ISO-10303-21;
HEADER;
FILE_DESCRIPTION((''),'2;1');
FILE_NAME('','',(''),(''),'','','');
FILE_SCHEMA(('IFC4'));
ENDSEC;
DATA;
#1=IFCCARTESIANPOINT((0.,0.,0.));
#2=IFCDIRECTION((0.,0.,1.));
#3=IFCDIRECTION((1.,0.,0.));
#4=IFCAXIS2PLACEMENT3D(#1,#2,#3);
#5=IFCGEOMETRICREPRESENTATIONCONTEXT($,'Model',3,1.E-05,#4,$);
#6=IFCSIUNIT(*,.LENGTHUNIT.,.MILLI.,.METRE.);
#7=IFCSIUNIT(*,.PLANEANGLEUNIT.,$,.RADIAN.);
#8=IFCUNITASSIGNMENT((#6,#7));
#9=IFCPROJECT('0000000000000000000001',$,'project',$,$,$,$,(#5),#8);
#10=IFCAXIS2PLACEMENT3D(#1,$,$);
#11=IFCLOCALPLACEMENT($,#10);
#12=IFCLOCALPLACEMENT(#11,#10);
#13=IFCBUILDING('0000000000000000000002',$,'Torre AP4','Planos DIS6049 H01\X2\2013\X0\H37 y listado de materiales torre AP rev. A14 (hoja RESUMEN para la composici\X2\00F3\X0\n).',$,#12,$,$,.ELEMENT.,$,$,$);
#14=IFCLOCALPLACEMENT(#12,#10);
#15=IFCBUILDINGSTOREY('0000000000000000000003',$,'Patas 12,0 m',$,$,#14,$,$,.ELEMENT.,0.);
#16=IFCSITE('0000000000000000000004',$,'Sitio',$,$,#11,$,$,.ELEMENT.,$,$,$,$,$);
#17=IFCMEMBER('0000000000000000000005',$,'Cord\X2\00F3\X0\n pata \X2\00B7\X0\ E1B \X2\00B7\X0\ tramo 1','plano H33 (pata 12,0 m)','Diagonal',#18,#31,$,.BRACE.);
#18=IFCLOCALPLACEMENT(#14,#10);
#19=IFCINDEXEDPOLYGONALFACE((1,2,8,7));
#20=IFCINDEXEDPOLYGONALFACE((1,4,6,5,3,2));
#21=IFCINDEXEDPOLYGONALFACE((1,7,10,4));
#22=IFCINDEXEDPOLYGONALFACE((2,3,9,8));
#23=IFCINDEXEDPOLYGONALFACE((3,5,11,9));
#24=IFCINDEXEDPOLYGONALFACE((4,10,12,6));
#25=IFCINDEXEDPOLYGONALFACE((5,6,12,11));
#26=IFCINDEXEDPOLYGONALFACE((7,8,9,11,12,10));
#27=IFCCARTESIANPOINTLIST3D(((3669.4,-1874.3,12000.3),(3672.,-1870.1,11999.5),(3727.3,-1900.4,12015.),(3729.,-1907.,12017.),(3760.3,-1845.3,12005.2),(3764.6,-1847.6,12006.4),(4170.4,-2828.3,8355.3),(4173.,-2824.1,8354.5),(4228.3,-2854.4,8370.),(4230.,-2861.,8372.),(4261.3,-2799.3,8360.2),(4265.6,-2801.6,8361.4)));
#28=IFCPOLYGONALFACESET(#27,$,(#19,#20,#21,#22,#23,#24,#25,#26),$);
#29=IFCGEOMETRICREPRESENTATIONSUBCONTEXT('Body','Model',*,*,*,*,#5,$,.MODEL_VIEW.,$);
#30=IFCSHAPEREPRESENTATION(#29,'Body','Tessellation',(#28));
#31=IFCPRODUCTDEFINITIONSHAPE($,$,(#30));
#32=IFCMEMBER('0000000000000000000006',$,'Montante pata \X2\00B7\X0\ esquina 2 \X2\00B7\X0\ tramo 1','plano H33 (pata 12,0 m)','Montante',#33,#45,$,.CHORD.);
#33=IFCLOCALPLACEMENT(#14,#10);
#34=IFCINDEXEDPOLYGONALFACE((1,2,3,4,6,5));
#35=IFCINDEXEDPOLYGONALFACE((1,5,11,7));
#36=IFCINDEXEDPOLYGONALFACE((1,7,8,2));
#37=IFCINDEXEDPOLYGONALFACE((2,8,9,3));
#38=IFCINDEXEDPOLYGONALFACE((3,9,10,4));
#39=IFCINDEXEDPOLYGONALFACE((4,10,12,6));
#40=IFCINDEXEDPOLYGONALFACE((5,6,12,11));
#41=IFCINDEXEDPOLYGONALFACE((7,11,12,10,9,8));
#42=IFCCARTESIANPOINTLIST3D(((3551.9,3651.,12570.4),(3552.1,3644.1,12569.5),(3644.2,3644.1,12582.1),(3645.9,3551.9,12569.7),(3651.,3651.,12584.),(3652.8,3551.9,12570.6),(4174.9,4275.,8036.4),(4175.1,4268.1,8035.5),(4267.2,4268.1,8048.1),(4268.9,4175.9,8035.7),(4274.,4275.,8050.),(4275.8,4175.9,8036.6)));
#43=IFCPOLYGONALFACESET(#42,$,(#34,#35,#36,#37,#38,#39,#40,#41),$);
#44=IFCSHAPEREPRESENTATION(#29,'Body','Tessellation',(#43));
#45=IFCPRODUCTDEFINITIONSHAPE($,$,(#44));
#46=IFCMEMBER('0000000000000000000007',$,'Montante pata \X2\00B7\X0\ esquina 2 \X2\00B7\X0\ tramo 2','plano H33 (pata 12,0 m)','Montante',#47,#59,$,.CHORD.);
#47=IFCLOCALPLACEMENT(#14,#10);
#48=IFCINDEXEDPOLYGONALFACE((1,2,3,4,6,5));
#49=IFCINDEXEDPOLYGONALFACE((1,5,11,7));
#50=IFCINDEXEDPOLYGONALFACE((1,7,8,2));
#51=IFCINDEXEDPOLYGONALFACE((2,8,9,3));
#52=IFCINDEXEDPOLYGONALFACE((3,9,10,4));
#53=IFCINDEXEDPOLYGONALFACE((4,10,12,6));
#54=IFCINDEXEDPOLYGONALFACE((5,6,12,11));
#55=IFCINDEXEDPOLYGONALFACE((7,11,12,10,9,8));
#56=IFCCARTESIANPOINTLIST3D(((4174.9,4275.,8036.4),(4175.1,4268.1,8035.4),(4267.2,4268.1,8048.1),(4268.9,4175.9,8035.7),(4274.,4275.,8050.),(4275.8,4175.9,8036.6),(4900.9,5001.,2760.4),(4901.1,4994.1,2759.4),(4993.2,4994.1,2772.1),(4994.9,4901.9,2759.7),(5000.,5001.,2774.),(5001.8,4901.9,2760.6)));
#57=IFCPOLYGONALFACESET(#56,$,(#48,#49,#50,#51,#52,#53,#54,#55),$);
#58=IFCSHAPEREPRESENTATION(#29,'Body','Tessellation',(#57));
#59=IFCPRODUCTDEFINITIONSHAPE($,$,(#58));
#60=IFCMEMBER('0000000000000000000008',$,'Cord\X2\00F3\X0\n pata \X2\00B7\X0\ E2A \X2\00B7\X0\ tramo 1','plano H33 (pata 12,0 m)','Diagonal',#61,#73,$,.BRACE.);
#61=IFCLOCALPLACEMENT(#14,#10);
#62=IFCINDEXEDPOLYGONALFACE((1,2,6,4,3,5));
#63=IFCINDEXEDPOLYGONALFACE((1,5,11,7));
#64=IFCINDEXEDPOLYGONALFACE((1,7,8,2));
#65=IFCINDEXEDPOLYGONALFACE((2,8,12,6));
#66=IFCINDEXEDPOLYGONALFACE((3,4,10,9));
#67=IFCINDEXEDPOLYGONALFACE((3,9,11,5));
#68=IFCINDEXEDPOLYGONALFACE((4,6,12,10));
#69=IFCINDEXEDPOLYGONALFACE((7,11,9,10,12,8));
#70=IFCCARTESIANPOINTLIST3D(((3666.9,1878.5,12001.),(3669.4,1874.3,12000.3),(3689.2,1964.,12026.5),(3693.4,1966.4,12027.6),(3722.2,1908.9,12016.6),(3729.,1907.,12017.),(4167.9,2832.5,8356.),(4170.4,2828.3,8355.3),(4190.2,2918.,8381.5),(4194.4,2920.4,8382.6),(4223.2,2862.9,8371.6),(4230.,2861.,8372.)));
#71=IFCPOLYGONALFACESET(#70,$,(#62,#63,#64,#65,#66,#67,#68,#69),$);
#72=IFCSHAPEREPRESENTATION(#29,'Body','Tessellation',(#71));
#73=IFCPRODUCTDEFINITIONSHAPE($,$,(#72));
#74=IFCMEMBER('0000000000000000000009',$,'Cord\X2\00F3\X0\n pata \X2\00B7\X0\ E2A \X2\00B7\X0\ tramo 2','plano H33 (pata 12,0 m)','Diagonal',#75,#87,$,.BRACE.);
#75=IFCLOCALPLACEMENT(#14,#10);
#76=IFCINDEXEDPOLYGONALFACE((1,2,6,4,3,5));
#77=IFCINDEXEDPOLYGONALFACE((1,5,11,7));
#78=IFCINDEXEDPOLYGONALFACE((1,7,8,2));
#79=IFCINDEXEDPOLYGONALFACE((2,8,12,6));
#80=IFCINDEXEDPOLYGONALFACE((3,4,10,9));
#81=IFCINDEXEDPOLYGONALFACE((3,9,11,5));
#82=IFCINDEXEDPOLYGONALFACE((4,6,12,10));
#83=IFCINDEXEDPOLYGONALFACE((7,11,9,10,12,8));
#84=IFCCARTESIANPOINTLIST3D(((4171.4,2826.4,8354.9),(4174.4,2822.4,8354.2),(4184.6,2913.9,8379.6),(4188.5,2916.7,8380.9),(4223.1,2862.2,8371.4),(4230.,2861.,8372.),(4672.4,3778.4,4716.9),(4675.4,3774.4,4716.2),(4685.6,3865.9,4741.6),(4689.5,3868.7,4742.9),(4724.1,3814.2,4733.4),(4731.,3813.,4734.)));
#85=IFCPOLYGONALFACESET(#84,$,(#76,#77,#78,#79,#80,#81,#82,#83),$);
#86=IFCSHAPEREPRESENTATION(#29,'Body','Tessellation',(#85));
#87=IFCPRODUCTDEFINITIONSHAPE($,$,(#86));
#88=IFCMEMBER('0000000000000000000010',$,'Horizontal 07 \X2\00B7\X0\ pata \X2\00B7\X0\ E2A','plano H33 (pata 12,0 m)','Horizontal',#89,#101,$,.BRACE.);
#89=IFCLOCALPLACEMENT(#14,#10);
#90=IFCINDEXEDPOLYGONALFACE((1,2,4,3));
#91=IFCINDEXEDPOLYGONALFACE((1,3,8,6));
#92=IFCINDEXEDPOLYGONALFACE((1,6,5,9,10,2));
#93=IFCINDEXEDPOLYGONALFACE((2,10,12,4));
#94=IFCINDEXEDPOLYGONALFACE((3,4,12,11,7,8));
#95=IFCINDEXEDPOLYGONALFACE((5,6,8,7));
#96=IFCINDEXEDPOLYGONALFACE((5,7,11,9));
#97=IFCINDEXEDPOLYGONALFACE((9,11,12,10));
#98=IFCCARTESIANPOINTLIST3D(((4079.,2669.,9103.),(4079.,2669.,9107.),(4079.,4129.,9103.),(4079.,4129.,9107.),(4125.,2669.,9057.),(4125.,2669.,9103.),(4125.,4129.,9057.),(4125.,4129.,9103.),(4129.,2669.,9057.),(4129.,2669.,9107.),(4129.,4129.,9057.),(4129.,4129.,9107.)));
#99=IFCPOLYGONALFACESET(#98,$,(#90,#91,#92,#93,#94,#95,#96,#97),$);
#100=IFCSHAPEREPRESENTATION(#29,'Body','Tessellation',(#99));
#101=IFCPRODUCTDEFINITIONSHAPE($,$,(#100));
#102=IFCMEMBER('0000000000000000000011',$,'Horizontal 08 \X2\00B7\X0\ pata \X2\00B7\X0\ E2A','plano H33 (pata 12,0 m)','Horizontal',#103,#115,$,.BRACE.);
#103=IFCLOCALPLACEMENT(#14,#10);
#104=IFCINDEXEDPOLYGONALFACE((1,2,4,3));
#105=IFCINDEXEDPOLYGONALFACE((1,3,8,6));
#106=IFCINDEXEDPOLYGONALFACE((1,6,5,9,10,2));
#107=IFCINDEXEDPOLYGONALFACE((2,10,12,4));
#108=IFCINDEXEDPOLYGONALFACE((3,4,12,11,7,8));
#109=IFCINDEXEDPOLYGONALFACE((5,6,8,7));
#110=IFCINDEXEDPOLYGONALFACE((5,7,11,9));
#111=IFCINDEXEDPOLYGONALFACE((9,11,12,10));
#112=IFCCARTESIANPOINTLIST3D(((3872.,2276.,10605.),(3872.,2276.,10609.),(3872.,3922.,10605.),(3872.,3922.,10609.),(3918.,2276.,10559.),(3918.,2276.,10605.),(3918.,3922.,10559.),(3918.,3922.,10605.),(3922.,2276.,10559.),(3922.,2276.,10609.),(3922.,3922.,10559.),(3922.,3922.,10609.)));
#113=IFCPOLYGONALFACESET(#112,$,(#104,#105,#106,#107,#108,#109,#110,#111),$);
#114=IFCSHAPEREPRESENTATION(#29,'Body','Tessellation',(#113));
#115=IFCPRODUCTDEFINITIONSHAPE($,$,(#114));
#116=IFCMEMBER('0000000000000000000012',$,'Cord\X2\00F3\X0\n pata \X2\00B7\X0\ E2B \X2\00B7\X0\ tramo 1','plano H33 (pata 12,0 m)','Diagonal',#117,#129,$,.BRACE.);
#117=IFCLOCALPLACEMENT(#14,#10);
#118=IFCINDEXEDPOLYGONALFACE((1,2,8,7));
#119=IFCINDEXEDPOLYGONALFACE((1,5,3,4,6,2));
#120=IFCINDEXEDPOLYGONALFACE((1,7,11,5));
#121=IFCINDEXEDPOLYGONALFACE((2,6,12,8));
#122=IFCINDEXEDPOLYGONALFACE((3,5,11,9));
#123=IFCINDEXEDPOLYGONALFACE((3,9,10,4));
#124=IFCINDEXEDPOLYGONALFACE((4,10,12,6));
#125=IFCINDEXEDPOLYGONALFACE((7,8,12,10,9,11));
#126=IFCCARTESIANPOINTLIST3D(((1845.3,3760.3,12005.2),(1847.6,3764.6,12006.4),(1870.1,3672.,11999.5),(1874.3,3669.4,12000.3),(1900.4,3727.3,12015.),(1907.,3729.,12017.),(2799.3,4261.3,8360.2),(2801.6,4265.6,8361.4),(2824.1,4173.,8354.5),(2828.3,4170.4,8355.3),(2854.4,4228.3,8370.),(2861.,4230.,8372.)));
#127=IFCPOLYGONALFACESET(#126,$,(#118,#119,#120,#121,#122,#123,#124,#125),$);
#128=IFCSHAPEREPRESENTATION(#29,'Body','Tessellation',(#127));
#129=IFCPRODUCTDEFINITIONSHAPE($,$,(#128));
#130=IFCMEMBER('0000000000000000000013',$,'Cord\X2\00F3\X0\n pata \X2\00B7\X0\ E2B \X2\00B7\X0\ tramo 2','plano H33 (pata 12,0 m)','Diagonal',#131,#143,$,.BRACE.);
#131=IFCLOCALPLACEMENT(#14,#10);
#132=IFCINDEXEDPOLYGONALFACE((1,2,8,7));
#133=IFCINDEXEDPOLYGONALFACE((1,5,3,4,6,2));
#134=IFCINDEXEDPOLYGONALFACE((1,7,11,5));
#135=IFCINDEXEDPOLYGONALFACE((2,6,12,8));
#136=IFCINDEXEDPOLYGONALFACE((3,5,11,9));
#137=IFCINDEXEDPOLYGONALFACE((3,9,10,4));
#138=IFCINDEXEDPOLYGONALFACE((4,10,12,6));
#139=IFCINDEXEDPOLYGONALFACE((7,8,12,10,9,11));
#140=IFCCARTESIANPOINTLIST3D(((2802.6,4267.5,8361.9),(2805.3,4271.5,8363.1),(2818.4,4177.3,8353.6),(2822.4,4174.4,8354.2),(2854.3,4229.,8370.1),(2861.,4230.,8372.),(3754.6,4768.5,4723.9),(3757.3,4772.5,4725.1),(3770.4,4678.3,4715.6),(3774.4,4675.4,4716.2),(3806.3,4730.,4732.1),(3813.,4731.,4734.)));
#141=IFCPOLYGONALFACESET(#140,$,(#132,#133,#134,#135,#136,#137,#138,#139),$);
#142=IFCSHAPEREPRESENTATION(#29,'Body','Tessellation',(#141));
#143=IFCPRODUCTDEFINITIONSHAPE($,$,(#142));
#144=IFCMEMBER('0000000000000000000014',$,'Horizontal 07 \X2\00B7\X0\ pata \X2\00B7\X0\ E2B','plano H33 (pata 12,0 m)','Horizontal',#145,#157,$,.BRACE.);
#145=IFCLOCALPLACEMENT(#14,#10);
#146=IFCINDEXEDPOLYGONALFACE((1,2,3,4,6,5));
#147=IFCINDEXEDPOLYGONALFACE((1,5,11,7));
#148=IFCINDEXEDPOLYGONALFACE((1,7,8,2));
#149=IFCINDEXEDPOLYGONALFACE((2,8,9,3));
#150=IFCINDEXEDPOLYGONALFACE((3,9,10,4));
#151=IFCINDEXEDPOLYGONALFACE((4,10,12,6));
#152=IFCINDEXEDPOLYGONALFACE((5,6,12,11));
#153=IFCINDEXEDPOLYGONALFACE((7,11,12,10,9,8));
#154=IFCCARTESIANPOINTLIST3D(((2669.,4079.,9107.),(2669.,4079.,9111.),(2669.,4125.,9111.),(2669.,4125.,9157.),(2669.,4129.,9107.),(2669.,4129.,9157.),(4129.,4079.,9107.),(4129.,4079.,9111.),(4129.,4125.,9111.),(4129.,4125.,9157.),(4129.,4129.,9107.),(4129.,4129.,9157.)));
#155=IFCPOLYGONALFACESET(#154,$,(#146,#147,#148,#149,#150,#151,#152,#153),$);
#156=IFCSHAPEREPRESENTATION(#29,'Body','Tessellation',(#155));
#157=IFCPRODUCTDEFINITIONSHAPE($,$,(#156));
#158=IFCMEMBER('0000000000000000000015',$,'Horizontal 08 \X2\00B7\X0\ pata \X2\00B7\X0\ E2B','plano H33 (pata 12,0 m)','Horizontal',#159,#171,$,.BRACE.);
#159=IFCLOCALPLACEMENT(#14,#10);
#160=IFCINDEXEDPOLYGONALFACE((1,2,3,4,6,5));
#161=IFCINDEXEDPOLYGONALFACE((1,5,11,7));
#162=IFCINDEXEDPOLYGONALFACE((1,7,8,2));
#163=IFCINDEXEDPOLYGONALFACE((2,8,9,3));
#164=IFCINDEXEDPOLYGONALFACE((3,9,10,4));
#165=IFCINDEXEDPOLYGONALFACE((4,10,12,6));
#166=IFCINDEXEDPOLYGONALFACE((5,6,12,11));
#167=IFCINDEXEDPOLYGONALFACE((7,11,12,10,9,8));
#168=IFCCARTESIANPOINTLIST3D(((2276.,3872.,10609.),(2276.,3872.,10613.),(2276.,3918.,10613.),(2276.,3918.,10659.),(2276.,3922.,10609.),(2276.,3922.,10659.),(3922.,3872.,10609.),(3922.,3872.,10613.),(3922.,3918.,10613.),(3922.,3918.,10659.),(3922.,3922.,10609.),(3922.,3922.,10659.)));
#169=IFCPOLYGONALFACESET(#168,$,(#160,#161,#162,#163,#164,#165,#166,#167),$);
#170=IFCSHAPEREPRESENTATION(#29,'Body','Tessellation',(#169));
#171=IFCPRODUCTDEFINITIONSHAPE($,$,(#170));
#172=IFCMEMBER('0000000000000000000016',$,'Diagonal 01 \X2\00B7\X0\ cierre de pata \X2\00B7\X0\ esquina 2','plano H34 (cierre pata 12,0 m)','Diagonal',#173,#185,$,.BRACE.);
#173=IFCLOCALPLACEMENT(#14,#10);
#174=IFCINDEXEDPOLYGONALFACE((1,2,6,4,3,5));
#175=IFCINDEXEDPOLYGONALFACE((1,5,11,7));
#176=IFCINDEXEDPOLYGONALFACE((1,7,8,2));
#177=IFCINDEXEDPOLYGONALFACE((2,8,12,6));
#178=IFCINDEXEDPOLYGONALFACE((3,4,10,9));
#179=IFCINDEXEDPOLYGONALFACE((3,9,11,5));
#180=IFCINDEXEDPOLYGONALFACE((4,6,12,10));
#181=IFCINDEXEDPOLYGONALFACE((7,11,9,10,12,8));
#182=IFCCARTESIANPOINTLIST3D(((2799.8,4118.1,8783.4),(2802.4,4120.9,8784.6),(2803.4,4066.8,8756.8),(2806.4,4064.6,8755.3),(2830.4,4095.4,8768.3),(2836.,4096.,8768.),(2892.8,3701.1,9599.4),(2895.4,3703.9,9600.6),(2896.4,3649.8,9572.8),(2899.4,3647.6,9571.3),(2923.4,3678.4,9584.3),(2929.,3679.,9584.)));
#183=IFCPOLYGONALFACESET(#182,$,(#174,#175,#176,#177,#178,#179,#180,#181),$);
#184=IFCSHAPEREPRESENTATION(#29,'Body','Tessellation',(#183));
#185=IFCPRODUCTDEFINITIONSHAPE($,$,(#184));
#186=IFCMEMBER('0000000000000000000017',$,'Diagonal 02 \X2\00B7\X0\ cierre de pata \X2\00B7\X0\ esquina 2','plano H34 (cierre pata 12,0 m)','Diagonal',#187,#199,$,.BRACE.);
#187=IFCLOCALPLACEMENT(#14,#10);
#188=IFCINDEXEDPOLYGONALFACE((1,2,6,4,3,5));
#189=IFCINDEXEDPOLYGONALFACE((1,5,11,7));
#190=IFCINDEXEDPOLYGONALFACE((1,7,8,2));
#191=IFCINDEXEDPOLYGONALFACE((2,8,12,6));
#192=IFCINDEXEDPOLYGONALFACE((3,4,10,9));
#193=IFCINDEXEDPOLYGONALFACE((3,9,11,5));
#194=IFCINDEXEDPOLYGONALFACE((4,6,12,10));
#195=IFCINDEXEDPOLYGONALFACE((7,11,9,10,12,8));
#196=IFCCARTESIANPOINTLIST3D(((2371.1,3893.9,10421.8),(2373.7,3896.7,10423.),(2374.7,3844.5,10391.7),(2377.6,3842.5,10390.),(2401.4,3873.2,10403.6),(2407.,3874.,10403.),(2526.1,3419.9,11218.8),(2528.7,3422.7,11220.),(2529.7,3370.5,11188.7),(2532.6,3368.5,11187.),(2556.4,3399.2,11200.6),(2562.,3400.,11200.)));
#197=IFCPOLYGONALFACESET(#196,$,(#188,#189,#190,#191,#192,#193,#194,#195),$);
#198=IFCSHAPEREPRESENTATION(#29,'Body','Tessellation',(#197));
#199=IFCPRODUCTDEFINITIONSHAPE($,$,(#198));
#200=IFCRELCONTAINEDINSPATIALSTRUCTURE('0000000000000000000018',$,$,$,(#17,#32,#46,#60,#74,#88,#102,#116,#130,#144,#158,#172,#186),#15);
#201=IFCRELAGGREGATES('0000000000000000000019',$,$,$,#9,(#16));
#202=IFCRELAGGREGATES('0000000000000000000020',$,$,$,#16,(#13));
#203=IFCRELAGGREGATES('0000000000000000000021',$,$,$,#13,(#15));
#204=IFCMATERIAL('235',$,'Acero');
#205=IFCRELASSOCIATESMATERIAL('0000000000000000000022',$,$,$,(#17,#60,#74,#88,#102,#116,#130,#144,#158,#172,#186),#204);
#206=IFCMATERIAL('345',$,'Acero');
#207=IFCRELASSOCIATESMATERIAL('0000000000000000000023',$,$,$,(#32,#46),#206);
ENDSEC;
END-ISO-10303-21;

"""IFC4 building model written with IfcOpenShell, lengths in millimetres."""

from ifc_helpers import new_model, si_unit, frame, frame_2d, origin, origin_with_axes, place, context, subcontext, project, spatial, l_section, extrude, material, element, save


model = new_model("IFC4")

# Units and contexts
model_context = context("Model", 3, precision=1e-05, world=origin_with_axes())
body_context = subcontext(model_context, "Body", "Model", "MODEL_VIEW")
ifc_project = project(units=[si_unit("LENGTHUNIT", "METRE", prefix="MILLI"), si_unit("PLANEANGLEUNIT", "RADIAN")], contexts=[model_context])

# Site, building, storey
site_placement = place(None, origin())
site = spatial("IfcSite", under=ifc_project, at=site_placement, Name="Sitio", CompositionType="ELEMENT")
building_placement = place(site_placement, origin())
building = spatial("IfcBuilding", under=site, at=building_placement, Name="Torre AP4", Description="Planos DIS6049 H01–H37 y listado de materiales torre AP rev. A14 (hoja RESUMEN para la composición).", CompositionType="ELEMENT")
storey_placement = place(building_placement, origin())
storey = spatial("IfcBuildingStorey", under=building, at=storey_placement, Name="Patas 12,0 m", CompositionType="ELEMENT", Elevation=0.0)

# Members
ifc_material_1 = material(Name="235", Category="Acero")
member_1_placement = place(storey_placement, frame((3729.0, -1907.0, 12017.0), z_axis=(0.13181, -0.250991, -0.958973), x_axis=(-0.851254, 0.467044, -0.239242)))
element("IfcMember", 1, at=member_1_placement, inside=storey, material=ifc_material_1, Name="Cordón pata · E1B · tramo 1", Description="plano H33 (pata 12,0 m)", ObjectType="Diagonal", PredefinedType="BRACE", context=body_context, shape_type="SweptSolid", body=[
    extrude(l_section(Depth=70.0, Width=70.0, Thickness=5.0, at=frame_2d((35.0, 35.0))), None, (0.0, 0.0, 1.0), 3800.9),
])
ifc_material_2 = material(Name="345", Category="Acero")
member_2_placement = place(storey_placement, frame((3651.0, 3651.0, 12584.0), z_axis=(0.134879, 0.135096, -0.981609), x_axis=(0.01839, -0.990833, -0.133838)))
element("IfcMember", 2, at=member_2_placement, inside=storey, material=ifc_material_2, Name="Montante pata · esquina 2 · tramo 1", Description="plano H33 (pata 12,0 m)", ObjectType="Montante", PredefinedType="CHORD", context=body_context, shape_type="SweptSolid", body=[
    extrude(l_section(Depth=100.0, Width=100.0, Thickness=7.0, at=frame_2d((50.0, 50.0))), None, (0.0, 0.0, 1.0), 4618.9),
])
member_3_placement = place(storey_placement, frame((4274.0, 4275.0, 8050.0), z_axis=(0.13507, 0.13507, -0.981586), x_axis=(0.018413, -0.990836, -0.13381)))
element("IfcMember", 3, at=member_3_placement, inside=storey, material=ifc_material_2, Name="Montante pata · esquina 2 · tramo 2", Description="plano H33 (pata 12,0 m)", ObjectType="Montante", PredefinedType="CHORD", context=body_context, shape_type="SweptSolid", body=[
    extrude(l_section(Depth=100.0, Width=100.0, Thickness=7.0, at=frame_2d((50.0, 50.0))), None, (0.0, 0.0, 1.0), 5375.0),
])
member_4_placement = place(storey_placement, frame((3729.0, 1907.0, 12017.0), z_axis=(0.13181, 0.250991, -0.958973), x_axis=(-0.851254, -0.467044, -0.239242)))
element("IfcMember", 4, at=member_4_placement, inside=storey, material=ifc_material_1, Name="Cordón pata · E2A · tramo 1", Description="plano H33 (pata 12,0 m)", ObjectType="Diagonal", PredefinedType="BRACE", context=body_context, shape_type="SweptSolid", body=[
    extrude(l_section(Depth=70.0, Width=70.0, Thickness=5.0, at=frame_2d((35.0, 35.0))), None, (0.0, 0.0, 1.0), 3800.9),
])
member_5_placement = place(storey_placement, frame((4230.0, 2861.0, 8372.0), z_axis=(0.13206, 0.250941, -0.958952), x_axis=(-0.794662, -0.551475, -0.253747)))
element("IfcMember", 5, at=member_5_placement, inside=storey, material=ifc_material_1, Name="Cordón pata · E2A · tramo 2", Description="plano H33 (pata 12,0 m)", ObjectType="Diagonal", PredefinedType="BRACE", context=body_context, shape_type="SweptSolid", body=[
    extrude(l_section(Depth=70.0, Width=70.0, Thickness=5.0, at=frame_2d((35.0, 35.0))), None, (0.0, 0.0, 1.0), 3793.7),
])
member_6_placement = place(storey_placement, frame((4129.0, 4129.0, 9107.0), z_axis=(0.0, -1.0, 0.0), x_axis=(-1.0, 0.0, 0.0)))
element("IfcMember", 6, at=member_6_placement, inside=storey, material=ifc_material_1, Name="Horizontal 07 · pata · E2A", Description="plano H33 (pata 12,0 m)", ObjectType="Horizontal", PredefinedType="BRACE", context=body_context, shape_type="SweptSolid", body=[
    extrude(l_section(Depth=50.0, Width=50.0, Thickness=4.0, at=frame_2d((25.0, 25.0))), None, (0.0, 0.0, 1.0), 1460.0),
])
member_7_placement = place(storey_placement, frame((3922.0, 3922.0, 10609.0), z_axis=(0.0, -1.0, 0.0), x_axis=(-1.0, 0.0, 0.0)))
element("IfcMember", 7, at=member_7_placement, inside=storey, material=ifc_material_1, Name="Horizontal 08 · pata · E2A", Description="plano H33 (pata 12,0 m)", ObjectType="Horizontal", PredefinedType="BRACE", context=body_context, shape_type="SweptSolid", body=[
    extrude(l_section(Depth=50.0, Width=50.0, Thickness=4.0, at=frame_2d((25.0, 25.0))), None, (0.0, 0.0, 1.0), 1646.0),
])
member_8_placement = place(storey_placement, frame((1907.0, 3729.0, 12017.0), z_axis=(0.250991, 0.13181, -0.958973), x_axis=(-0.467044, -0.851254, -0.239242)))
element("IfcMember", 8, at=member_8_placement, inside=storey, material=ifc_material_1, Name="Cordón pata · E2B · tramo 1", Description="plano H33 (pata 12,0 m)", ObjectType="Diagonal", PredefinedType="BRACE", context=body_context, shape_type="SweptSolid", body=[
    extrude(l_section(Depth=70.0, Width=70.0, Thickness=5.0, at=frame_2d((35.0, 35.0))), None, (0.0, 0.0, 1.0), 3800.9),
])
member_9_placement = place(storey_placement, frame((2861.0, 4230.0, 8372.0), z_axis=(0.250941, 0.13206, -0.958952), x_axis=(-0.551475, -0.794662, -0.253747)))
element("IfcMember", 9, at=member_9_placement, inside=storey, material=ifc_material_1, Name="Cordón pata · E2B · tramo 2", Description="plano H33 (pata 12,0 m)", ObjectType="Diagonal", PredefinedType="BRACE", context=body_context, shape_type="SweptSolid", body=[
    extrude(l_section(Depth=70.0, Width=70.0, Thickness=5.0, at=frame_2d((35.0, 35.0))), None, (0.0, 0.0, 1.0), 3793.7),
])
member_10_placement = place(storey_placement, frame((4129.0, 4129.0, 9107.0), z_axis=(-1.0, 0.0, 0.0), x_axis=(0.0, -1.0, 0.0)))
element("IfcMember", 10, at=member_10_placement, inside=storey, material=ifc_material_1, Name="Horizontal 07 · pata · E2B", Description="plano H33 (pata 12,0 m)", ObjectType="Horizontal", PredefinedType="BRACE", context=body_context, shape_type="SweptSolid", body=[
    extrude(l_section(Depth=50.0, Width=50.0, Thickness=4.0, at=frame_2d((25.0, 25.0))), None, (0.0, 0.0, 1.0), 1460.0),
])
member_11_placement = place(storey_placement, frame((3922.0, 3922.0, 10609.0), z_axis=(-1.0, 0.0, 0.0), x_axis=(0.0, -1.0, 0.0)))
element("IfcMember", 11, at=member_11_placement, inside=storey, material=ifc_material_1, Name="Horizontal 08 · pata · E2B", Description="plano H33 (pata 12,0 m)", ObjectType="Horizontal", PredefinedType="BRACE", context=body_context, shape_type="SweptSolid", body=[
    extrude(l_section(Depth=50.0, Width=50.0, Thickness=4.0, at=frame_2d((25.0, 25.0))), None, (0.0, 0.0, 1.0), 1646.0),
])
member_12_placement = place(storey_placement, frame((2929.0, 3679.0, 9584.0), z_axis=(-0.100968, 0.452728, -0.885914), x_axis=(-0.657265, -0.698827, -0.282212)))
element("IfcMember", 12, at=member_12_placement, inside=storey, material=ifc_material_1, Name="Diagonal 01 · cierre de pata · esquina 2", Description="plano H34 (cierre pata 12,0 m)", ObjectType="Diagonal", PredefinedType="BRACE", context=body_context, shape_type="SweptSolid", body=[
    extrude(l_section(Depth=45.0, Width=45.0, Thickness=4.0, at=frame_2d((22.5, 22.5))), None, (0.0, 0.0, 1.0), 921.1),
])
member_13_placement = place(storey_placement, frame((2562.0, 3400.0, 11200.0), z_axis=(-0.164865, 0.504167, -0.847724), x_axis=(-0.65241, -0.700338, -0.289632)))
element("IfcMember", 13, at=member_13_placement, inside=storey, material=ifc_material_1, Name="Diagonal 02 · cierre de pata · esquina 2", Description="plano H34 (cierre pata 12,0 m)", ObjectType="Diagonal", PredefinedType="BRACE", context=body_context, shape_type="SweptSolid", body=[
    extrude(l_section(Depth=45.0, Width=45.0, Thickness=4.0, at=frame_2d((22.5, 22.5))), None, (0.0, 0.0, 1.0), 940.2),
])

save(model, "model.ifc")
